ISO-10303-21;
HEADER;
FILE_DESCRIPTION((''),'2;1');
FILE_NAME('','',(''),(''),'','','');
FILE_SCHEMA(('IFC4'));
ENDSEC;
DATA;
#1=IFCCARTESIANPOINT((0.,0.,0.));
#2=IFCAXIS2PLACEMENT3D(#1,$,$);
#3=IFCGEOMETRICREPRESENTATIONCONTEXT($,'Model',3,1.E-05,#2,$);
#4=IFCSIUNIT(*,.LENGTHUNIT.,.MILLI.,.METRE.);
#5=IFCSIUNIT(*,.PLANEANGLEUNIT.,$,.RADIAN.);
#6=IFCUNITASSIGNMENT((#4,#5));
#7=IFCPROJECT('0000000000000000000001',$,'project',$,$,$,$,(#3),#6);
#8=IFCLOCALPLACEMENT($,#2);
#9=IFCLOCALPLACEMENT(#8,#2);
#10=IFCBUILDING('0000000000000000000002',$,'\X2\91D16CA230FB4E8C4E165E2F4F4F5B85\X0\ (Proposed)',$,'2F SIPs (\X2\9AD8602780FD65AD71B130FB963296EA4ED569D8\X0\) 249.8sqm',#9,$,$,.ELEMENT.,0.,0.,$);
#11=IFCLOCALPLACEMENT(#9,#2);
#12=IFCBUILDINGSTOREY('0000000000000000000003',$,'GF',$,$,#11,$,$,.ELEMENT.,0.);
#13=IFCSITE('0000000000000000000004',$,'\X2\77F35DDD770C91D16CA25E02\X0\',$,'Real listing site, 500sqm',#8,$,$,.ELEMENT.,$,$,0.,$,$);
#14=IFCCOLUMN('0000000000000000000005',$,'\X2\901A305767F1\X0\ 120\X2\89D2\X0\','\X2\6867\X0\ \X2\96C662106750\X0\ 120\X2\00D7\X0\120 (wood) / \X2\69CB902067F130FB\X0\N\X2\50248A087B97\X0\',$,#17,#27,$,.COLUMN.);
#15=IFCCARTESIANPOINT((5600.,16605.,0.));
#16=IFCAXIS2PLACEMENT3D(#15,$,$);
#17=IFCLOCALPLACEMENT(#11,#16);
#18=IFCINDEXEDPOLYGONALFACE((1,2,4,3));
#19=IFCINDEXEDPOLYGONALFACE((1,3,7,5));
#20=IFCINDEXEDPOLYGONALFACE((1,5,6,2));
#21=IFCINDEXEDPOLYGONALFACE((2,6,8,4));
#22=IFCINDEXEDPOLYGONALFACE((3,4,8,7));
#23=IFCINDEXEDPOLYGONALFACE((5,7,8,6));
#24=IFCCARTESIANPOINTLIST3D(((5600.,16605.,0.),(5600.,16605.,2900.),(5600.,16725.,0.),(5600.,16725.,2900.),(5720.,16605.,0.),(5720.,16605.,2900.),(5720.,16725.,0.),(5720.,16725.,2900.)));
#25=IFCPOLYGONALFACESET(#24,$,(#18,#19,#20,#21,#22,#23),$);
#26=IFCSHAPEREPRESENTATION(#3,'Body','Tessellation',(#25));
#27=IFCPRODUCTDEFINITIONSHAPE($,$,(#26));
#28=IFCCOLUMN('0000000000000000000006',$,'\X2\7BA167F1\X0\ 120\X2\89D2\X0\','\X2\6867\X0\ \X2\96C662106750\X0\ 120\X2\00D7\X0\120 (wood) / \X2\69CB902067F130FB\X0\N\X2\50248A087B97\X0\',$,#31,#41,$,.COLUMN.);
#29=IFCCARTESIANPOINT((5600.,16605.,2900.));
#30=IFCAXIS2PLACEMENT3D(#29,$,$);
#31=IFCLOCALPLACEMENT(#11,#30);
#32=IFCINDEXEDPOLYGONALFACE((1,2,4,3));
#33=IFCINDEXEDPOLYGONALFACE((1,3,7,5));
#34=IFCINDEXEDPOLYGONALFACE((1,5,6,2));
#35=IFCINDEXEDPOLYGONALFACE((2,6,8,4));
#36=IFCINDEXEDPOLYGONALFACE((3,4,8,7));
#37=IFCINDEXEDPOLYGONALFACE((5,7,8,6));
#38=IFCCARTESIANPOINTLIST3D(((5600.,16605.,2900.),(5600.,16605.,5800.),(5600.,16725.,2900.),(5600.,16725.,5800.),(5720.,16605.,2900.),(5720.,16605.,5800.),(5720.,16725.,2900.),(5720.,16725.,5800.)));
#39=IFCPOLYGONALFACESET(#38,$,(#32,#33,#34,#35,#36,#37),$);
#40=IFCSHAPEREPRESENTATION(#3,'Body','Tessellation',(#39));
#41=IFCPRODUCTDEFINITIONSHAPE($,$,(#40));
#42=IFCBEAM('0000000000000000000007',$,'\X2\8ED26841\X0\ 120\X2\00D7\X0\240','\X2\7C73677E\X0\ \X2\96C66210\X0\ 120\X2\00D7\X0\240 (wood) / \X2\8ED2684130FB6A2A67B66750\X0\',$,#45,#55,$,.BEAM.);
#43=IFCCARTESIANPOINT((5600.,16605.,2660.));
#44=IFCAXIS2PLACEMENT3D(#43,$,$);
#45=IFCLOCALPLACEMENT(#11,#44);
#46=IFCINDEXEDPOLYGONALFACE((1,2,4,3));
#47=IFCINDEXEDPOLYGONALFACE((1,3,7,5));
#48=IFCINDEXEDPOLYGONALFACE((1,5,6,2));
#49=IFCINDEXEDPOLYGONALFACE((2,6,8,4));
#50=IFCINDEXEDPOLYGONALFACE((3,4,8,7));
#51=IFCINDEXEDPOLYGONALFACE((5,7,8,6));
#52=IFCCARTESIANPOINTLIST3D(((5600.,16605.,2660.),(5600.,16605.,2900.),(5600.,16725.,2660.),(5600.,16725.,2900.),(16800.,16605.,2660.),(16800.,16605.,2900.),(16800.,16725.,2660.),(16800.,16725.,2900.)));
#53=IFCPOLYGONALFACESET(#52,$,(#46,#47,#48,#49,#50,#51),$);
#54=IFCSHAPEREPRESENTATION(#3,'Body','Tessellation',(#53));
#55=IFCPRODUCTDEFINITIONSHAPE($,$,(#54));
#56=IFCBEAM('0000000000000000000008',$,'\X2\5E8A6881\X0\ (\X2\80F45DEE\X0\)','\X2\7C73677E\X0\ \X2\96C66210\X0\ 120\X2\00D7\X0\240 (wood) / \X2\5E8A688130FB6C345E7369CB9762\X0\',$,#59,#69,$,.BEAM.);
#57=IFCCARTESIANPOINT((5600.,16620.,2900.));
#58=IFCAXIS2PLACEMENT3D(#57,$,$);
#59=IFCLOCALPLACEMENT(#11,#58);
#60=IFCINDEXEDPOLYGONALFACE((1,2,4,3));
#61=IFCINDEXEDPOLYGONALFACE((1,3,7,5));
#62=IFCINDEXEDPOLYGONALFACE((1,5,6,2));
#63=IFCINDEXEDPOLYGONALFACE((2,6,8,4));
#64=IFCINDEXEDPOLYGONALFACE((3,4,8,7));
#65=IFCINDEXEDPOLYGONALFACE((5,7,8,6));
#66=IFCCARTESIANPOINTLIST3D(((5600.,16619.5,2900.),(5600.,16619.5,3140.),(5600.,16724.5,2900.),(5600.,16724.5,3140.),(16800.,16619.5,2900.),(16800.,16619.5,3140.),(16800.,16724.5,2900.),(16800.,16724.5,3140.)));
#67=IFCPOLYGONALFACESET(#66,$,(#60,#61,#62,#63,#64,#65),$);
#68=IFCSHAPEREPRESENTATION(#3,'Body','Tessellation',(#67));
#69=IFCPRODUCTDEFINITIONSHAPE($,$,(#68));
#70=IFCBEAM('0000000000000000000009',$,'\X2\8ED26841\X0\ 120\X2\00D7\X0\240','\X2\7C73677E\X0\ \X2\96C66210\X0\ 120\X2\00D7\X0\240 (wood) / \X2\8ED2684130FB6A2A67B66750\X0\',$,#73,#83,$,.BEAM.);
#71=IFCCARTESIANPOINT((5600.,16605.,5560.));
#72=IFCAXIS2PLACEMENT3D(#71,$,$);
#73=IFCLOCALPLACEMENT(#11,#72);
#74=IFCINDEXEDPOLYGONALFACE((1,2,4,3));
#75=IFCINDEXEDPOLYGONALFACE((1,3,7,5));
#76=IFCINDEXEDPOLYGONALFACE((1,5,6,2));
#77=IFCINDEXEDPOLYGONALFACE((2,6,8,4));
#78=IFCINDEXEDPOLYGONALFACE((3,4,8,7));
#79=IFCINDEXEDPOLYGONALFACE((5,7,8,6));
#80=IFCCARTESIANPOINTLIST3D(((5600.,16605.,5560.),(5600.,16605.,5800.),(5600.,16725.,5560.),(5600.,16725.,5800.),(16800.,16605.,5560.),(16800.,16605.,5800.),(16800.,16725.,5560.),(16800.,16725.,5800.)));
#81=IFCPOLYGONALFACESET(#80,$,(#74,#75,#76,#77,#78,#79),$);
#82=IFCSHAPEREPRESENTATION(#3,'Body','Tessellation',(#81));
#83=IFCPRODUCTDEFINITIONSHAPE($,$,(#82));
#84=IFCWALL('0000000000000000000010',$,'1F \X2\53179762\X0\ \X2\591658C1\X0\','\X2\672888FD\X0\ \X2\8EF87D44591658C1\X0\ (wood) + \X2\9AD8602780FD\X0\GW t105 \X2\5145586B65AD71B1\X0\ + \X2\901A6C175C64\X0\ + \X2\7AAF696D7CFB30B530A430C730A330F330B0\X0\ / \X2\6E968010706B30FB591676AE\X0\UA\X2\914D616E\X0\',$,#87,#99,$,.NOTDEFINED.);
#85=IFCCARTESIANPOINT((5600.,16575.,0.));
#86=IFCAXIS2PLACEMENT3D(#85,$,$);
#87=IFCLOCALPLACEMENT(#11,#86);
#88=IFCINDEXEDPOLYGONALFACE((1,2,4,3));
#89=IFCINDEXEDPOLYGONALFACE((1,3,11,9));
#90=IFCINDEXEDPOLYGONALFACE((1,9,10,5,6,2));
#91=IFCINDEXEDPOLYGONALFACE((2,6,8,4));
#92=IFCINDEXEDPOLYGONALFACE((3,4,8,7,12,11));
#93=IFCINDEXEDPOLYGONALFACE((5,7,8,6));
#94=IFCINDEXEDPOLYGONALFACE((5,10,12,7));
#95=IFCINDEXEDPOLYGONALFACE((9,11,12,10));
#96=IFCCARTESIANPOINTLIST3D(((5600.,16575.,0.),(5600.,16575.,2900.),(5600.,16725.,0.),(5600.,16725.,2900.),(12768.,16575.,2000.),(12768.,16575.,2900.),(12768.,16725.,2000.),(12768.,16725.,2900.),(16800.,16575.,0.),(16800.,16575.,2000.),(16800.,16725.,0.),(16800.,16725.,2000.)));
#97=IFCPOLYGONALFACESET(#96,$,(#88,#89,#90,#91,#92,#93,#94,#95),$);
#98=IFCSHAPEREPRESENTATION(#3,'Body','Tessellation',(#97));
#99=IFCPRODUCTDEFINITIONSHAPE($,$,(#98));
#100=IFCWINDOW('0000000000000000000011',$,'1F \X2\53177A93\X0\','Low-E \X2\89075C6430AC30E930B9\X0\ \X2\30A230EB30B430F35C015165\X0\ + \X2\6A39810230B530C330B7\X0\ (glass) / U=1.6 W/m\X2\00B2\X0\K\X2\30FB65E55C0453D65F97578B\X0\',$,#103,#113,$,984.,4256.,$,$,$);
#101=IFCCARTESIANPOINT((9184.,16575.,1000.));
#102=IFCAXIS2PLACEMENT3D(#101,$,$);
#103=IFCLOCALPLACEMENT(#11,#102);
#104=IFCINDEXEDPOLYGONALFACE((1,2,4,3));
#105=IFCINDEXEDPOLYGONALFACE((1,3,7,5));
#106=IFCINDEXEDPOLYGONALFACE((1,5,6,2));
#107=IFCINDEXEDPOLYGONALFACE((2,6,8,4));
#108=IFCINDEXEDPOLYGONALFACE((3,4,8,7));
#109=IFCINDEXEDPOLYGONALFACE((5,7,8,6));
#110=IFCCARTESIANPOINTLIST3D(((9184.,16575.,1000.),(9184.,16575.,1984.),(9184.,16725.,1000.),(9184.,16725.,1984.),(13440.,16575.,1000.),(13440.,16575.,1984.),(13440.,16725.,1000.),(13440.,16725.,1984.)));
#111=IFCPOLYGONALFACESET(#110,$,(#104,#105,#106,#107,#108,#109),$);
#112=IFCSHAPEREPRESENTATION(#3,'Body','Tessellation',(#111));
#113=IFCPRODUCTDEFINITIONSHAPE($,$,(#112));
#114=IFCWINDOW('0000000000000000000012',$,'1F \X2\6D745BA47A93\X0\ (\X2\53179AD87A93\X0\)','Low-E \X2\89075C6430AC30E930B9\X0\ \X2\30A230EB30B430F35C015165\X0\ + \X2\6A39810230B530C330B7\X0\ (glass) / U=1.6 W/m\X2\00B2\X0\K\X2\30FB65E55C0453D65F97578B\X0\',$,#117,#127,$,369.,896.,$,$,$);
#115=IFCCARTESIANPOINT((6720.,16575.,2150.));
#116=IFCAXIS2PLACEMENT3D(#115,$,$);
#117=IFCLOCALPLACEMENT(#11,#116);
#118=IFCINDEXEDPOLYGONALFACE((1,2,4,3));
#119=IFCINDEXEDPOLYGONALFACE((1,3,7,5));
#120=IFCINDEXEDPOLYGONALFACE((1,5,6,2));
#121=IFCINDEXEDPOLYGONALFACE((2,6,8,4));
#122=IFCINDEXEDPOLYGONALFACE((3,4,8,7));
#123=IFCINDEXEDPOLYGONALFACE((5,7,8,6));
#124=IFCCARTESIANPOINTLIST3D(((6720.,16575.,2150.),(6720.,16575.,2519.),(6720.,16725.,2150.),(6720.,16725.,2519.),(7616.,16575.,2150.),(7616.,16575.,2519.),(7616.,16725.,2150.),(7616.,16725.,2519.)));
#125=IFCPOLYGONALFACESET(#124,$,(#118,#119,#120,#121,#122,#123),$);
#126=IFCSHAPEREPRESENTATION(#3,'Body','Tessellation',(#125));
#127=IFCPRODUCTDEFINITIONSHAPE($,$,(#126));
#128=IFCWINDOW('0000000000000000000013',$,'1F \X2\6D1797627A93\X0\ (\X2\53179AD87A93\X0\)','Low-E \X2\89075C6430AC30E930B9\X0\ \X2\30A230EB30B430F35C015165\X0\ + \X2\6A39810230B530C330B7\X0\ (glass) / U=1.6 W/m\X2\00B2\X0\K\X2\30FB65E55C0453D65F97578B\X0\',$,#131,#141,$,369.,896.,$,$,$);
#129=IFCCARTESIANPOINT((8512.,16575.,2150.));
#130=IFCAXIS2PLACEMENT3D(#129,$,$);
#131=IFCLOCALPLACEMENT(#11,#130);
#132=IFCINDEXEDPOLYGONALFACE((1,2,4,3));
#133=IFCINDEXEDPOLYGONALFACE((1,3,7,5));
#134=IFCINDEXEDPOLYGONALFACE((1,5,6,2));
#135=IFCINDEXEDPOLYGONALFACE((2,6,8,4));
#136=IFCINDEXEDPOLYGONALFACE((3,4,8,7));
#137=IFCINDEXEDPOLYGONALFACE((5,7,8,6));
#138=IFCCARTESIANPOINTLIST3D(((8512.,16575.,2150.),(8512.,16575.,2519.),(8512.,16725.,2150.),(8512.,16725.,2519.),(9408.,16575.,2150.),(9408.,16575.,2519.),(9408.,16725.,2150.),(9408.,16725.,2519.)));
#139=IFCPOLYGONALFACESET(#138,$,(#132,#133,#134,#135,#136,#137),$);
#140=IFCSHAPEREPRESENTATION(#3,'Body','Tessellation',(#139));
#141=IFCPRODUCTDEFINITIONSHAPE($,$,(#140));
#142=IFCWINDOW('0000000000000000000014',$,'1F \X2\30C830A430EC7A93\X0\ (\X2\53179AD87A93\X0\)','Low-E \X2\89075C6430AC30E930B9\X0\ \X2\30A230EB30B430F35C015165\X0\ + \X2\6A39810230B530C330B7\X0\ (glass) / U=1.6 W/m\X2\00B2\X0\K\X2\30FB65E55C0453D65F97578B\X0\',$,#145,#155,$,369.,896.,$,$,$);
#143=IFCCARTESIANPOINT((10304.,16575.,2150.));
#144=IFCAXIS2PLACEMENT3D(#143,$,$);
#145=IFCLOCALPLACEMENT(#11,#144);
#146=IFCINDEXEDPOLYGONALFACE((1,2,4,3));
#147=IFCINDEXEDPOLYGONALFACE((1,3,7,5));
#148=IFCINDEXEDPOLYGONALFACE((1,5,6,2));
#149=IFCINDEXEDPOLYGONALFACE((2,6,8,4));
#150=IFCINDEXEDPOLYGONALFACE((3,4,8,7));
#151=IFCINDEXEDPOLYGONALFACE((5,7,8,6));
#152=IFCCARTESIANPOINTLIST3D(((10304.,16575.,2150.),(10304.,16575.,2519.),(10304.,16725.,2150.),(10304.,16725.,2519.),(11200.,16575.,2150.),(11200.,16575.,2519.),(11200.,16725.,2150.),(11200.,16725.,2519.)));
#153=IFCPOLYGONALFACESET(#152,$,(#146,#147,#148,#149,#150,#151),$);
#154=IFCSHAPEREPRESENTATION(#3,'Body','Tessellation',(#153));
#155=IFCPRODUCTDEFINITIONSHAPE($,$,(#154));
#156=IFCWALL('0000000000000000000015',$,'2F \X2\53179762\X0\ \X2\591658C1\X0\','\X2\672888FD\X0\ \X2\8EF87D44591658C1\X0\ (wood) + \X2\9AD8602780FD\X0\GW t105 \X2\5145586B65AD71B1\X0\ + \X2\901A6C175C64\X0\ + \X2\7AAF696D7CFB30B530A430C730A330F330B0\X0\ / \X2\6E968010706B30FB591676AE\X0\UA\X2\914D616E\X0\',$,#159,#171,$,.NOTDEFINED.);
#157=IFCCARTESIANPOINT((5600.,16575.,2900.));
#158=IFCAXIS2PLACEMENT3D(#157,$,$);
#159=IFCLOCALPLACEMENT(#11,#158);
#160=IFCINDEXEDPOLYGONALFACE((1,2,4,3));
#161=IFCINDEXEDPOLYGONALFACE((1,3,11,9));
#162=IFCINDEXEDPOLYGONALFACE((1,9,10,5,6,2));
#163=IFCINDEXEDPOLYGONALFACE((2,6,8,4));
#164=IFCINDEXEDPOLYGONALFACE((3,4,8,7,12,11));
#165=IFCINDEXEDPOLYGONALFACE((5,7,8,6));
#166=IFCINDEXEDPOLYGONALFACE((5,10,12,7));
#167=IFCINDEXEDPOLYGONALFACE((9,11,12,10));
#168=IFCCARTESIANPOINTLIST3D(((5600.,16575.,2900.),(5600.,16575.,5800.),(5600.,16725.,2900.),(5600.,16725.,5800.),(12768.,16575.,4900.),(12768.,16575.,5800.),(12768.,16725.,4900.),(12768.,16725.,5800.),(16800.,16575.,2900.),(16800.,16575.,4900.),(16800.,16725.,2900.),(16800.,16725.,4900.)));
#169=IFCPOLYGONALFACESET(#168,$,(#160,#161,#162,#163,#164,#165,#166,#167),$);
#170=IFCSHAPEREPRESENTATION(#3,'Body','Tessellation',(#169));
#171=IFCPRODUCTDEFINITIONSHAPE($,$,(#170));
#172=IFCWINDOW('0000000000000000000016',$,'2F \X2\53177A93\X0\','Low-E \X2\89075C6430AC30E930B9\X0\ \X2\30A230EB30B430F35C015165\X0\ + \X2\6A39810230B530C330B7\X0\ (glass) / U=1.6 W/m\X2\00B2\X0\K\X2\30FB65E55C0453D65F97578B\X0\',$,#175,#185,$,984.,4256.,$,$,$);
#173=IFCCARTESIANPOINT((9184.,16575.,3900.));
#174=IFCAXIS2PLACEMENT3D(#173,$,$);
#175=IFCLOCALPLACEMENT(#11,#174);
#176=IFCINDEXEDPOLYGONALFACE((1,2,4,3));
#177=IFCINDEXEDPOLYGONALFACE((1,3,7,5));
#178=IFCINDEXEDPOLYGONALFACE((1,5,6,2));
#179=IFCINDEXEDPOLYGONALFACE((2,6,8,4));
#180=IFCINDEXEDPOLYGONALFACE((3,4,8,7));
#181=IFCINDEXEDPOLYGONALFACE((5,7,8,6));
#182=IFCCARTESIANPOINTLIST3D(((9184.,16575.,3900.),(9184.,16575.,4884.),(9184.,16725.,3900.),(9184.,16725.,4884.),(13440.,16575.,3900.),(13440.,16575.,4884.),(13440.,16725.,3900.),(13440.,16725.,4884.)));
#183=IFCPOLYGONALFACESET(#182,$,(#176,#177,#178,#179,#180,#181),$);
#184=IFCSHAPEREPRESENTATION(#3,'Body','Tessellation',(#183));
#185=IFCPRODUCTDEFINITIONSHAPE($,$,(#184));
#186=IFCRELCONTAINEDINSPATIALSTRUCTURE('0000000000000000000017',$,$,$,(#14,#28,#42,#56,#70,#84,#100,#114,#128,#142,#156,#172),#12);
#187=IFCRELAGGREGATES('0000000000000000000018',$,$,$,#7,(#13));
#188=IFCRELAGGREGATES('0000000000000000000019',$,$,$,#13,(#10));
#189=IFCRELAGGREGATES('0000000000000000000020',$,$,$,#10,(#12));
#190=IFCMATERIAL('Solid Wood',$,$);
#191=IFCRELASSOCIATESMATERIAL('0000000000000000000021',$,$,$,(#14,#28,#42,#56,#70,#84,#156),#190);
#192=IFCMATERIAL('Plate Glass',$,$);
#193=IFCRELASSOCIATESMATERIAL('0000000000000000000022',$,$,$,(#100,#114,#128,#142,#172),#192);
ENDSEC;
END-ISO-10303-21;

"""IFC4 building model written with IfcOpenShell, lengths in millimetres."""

from ifc_helpers import new_model, si_unit, frame, frame_2d, origin, place, context, project, spatial, rectangle, extrude, material, element, fill, save


model = new_model("IFC4")

# Units and contexts
model_context = context("Model", 3, precision=1e-05, world=origin())
ifc_project = project(units=[si_unit("LENGTHUNIT", "METRE", prefix="MILLI"), si_unit("PLANEANGLEUNIT", "RADIAN")], contexts=[model_context])

# Site, building, storey
site_placement = place(None, origin())
site = spatial("IfcSite", under=ifc_project, at=site_placement, Name="石川県金沢市", ObjectType="Real listing site, 500sqm", CompositionType="ELEMENT", RefElevation=0.0)
building_placement = place(site_placement, origin())
building = spatial("IfcBuilding", under=site, at=building_placement, Name="金沢・二世帯住宅 (Proposed)", ObjectType="2F SIPs (高性能断熱・防雪仕様) 249.8sqm", CompositionType="ELEMENT", ElevationOfRefHeight=0.0, ElevationOfTerrain=0.0)
storey_placement = place(building_placement, origin())
storey = spatial("IfcBuildingStorey", under=building, at=storey_placement, Name="GF", CompositionType="ELEMENT", Elevation=0.0)

# Columns
ifc_material_1 = material(Name="Solid Wood")
column_1_placement = place(storey_placement, frame((5600.0, 16605.0, 0.0)))
element("IfcColumn", 1, at=column_1_placement, inside=storey, material=ifc_material_1, Name="通し柱 120角", Description="桧 集成材 120×120 (wood) / 構造柱・N値計算", PredefinedType="COLUMN", context=model_context, shape_type="SweptSolid", body=[
    extrude(rectangle(XDim=120.0, YDim=120.0, at=frame_2d((60.0, 60.0))), frame((5600.0, 16605.0, 0.0)), (0.0, 0.0, 1.0), 2900.0),
])
column_2_placement = place(storey_placement, frame((5600.0, 16605.0, 2900.0)))
element("IfcColumn", 2, at=column_2_placement, inside=storey, material=ifc_material_1, Name="管柱 120角", Description="桧 集成材 120×120 (wood) / 構造柱・N値計算", PredefinedType="COLUMN", context=model_context, shape_type="SweptSolid", body=[
    extrude(rectangle(XDim=120.0, YDim=120.0, at=frame_2d((60.0, 60.0))), frame((5600.0, 16605.0, 2900.0)), (0.0, 0.0, 1.0), 2900.0),
])

# Beams
beam_1_placement = place(storey_placement, frame((5600.0, 16605.0, 2660.0)))
element("IfcBeam", 3, at=beam_1_placement, inside=storey, material=ifc_material_1, Name="軒桁 120×240", Description="米松 集成 120×240 (wood) / 軒桁・横架材", PredefinedType="BEAM", context=model_context, shape_type="SweptSolid", body=[
    extrude(rectangle(XDim=11200.0, YDim=120.0, at=frame_2d((5600.0, 60.0))), frame((5600.0, 16605.0, 2660.0)), (0.0, 0.0, 1.0), 240.0),
])
beam_2_placement = place(storey_placement, frame((5600.0, 16620.0, 2900.0)))
element("IfcBeam", 4, at=beam_2_placement, inside=storey, material=ifc_material_1, Name="床梁 (胴差)", Description="米松 集成 120×240 (wood) / 床梁・水平構面", PredefinedType="BEAM", context=model_context, shape_type="SweptSolid", body=[
    extrude(rectangle(XDim=11200.0, YDim=105.0, at=frame_2d((5600.0, 52.0))), frame((5600.0, 16620.0, 2900.0)), (0.0, 0.0, 1.0), 240.0),
])
beam_3_placement = place(storey_placement, frame((5600.0, 16605.0, 5560.0)))
element("IfcBeam", 5, at=beam_3_placement, inside=storey, material=ifc_material_1, Name="軒桁 120×240", Description="米松 集成 120×240 (wood) / 軒桁・横架材", PredefinedType="BEAM", context=model_context, shape_type="SweptSolid", body=[
    extrude(rectangle(XDim=11200.0, YDim=120.0, at=frame_2d((5600.0, 60.0))), frame((5600.0, 16605.0, 5560.0)), (0.0, 0.0, 1.0), 240.0),
])

# Wall, openings, windows
wall_1_placement = place(storey_placement, frame((5600.0, 16575.0, 0.0)))
wall_1 = element("IfcWall", 6, at=wall_1_placement, inside=storey, material=ifc_material_1, Name="1F 北面 外壁", Description="木製 軸組外壁 (wood) + 高性能GW t105 充填断熱 + 通気層 + 窯業系サイディング / 準耐火・外皮UA配慮", PredefinedType="NOTDEFINED", context=model_context, shape_type="SweptSolid", body=[
    extrude(rectangle(XDim=11200.0, YDim=150.0, at=frame_2d((5600.0, 75.0))), frame((5600.0, 16575.0, 0.0)), (0.0, 0.0, 1.0), 2900.0),
])
opening_1_placement = place(storey_placement, frame((9184.0, 16575.0, 1000.0)))
opening_1 = element("IfcOpeningElement", 7, at=opening_1_placement, cuts=wall_1, PredefinedType="NOTDEFINED", context=model_context, shape_type="SweptSolid", body=[
    extrude(rectangle(XDim=4256.0, YDim=150.0, at=frame_2d((2128.0, 75.0))), frame((9184.0, 16575.0, 1000.0)), (0.0, 0.0, 1.0), 984.0),
])
opening_2_placement = place(storey_placement, frame((6720.0, 16575.0, 2150.0)))
opening_2 = element("IfcOpeningElement", 8, at=opening_2_placement, cuts=wall_1, PredefinedType="NOTDEFINED", context=model_context, shape_type="SweptSolid", body=[
    extrude(rectangle(XDim=896.0, YDim=150.0, at=frame_2d((448.0, 75.0))), frame((6720.0, 16575.0, 2150.0)), (0.0, 0.0, 1.0), 369.0),
])
opening_3_placement = place(storey_placement, frame((8512.0, 16575.0, 2150.0)))
opening_3 = element("IfcOpeningElement", 9, at=opening_3_placement, cuts=wall_1, PredefinedType="NOTDEFINED", context=model_context, shape_type="SweptSolid", body=[
    extrude(rectangle(XDim=896.0, YDim=150.0, at=frame_2d((448.0, 75.0))), frame((8512.0, 16575.0, 2150.0)), (0.0, 0.0, 1.0), 369.0),
])
opening_4_placement = place(storey_placement, frame((10304.0, 16575.0, 2150.0)))
opening_4 = element("IfcOpeningElement", 10, at=opening_4_placement, cuts=wall_1, PredefinedType="NOTDEFINED", context=model_context, shape_type="SweptSolid", body=[
    extrude(rectangle(XDim=896.0, YDim=150.0, at=frame_2d((448.0, 75.0))), frame((10304.0, 16575.0, 2150.0)), (0.0, 0.0, 1.0), 369.0),
])
ifc_material_2 = material(Name="Plate Glass")
window_1_placement = place(storey_placement, frame((9184.0, 16575.0, 1000.0)))
window_1 = element("IfcWindow", 11, at=window_1_placement, inside=storey, material=ifc_material_2, Name="1F 北窓", Description="Low-E 複層ガラス アルゴン封入 + 樹脂サッシ (glass) / U=1.6 W/m²K・日射取得型", OverallHeight=984.0, OverallWidth=4256.0, context=model_context, shape_type="SweptSolid", body=[
    extrude(rectangle(XDim=4256.0, YDim=150.0, at=frame_2d((2128.0, 75.0))), frame((9184.0, 16575.0, 1000.0)), (0.0, 0.0, 1.0), 984.0),
])
fill(opening_1, window_1)
window_2_placement = place(storey_placement, frame((6720.0, 16575.0, 2150.0)))
window_2 = element("IfcWindow", 12, at=window_2_placement, inside=storey, material=ifc_material_2, Name="1F 浴室窓 (北高窓)", Description="Low-E 複層ガラス アルゴン封入 + 樹脂サッシ (glass) / U=1.6 W/m²K・日射取得型", OverallHeight=369.0, OverallWidth=896.0, context=model_context, shape_type="SweptSolid", body=[
    extrude(rectangle(XDim=896.0, YDim=150.0, at=frame_2d((448.0, 75.0))), frame((6720.0, 16575.0, 2150.0)), (0.0, 0.0, 1.0), 369.0),
])
fill(opening_2, window_2)
window_3_placement = place(storey_placement, frame((8512.0, 16575.0, 2150.0)))
window_3 = element("IfcWindow", 13, at=window_3_placement, inside=storey, material=ifc_material_2, Name="1F 洗面窓 (北高窓)", Description="Low-E 複層ガラス アルゴン封入 + 樹脂サッシ (glass) / U=1.6 W/m²K・日射取得型", OverallHeight=369.0, OverallWidth=896.0, context=model_context, shape_type="SweptSolid", body=[
    extrude(rectangle(XDim=896.0, YDim=150.0, at=frame_2d((448.0, 75.0))), frame((8512.0, 16575.0, 2150.0)), (0.0, 0.0, 1.0), 369.0),
])
fill(opening_3, window_3)
window_4_placement = place(storey_placement, frame((10304.0, 16575.0, 2150.0)))
window_4 = element("IfcWindow", 14, at=window_4_placement, inside=storey, material=ifc_material_2, Name="1F トイレ窓 (北高窓)", Description="Low-E 複層ガラス アルゴン封入 + 樹脂サッシ (glass) / U=1.6 W/m²K・日射取得型", OverallHeight=369.0, OverallWidth=896.0, context=model_context, shape_type="SweptSolid", body=[
    extrude(rectangle(XDim=896.0, YDim=150.0, at=frame_2d((448.0, 75.0))), frame((10304.0, 16575.0, 2150.0)), (0.0, 0.0, 1.0), 369.0),
])
fill(opening_4, window_4)

# Wall, opening, window
wall_2_placement = place(storey_placement, frame((5600.0, 16575.0, 2900.0)))
wall_2 = element("IfcWall", 15, at=wall_2_placement, inside=storey, material=ifc_material_1, Name="2F 北面 外壁", Description="木製 軸組外壁 (wood) + 高性能GW t105 充填断熱 + 通気層 + 窯業系サイディング / 準耐火・外皮UA配慮", PredefinedType="NOTDEFINED", context=model_context, shape_type="SweptSolid", body=[
    extrude(rectangle(XDim=11200.0, YDim=150.0, at=frame_2d((5600.0, 75.0))), frame((5600.0, 16575.0, 2900.0)), (0.0, 0.0, 1.0), 2900.0),
])
opening_5_placement = place(storey_placement, frame((9184.0, 16575.0, 3900.0)))
opening_5 = element("IfcOpeningElement", 16, at=opening_5_placement, cuts=wall_2, PredefinedType="NOTDEFINED", context=model_context, shape_type="SweptSolid", body=[
    extrude(rectangle(XDim=4256.0, YDim=150.0, at=frame_2d((2128.0, 75.0))), frame((9184.0, 16575.0, 3900.0)), (0.0, 0.0, 1.0), 984.0),
])
window_5_placement = place(storey_placement, frame((9184.0, 16575.0, 3900.0)))
window_5 = element("IfcWindow", 17, at=window_5_placement, inside=storey, material=ifc_material_2, Name="2F 北窓", Description="Low-E 複層ガラス アルゴン封入 + 樹脂サッシ (glass) / U=1.6 W/m²K・日射取得型", OverallHeight=984.0, OverallWidth=4256.0, context=model_context, shape_type="SweptSolid", body=[
    extrude(rectangle(XDim=4256.0, YDim=150.0, at=frame_2d((2128.0, 75.0))), frame((9184.0, 16575.0, 3900.0)), (0.0, 0.0, 1.0), 984.0),
])
fill(opening_5, window_5)

save(model, "model.ifc")
